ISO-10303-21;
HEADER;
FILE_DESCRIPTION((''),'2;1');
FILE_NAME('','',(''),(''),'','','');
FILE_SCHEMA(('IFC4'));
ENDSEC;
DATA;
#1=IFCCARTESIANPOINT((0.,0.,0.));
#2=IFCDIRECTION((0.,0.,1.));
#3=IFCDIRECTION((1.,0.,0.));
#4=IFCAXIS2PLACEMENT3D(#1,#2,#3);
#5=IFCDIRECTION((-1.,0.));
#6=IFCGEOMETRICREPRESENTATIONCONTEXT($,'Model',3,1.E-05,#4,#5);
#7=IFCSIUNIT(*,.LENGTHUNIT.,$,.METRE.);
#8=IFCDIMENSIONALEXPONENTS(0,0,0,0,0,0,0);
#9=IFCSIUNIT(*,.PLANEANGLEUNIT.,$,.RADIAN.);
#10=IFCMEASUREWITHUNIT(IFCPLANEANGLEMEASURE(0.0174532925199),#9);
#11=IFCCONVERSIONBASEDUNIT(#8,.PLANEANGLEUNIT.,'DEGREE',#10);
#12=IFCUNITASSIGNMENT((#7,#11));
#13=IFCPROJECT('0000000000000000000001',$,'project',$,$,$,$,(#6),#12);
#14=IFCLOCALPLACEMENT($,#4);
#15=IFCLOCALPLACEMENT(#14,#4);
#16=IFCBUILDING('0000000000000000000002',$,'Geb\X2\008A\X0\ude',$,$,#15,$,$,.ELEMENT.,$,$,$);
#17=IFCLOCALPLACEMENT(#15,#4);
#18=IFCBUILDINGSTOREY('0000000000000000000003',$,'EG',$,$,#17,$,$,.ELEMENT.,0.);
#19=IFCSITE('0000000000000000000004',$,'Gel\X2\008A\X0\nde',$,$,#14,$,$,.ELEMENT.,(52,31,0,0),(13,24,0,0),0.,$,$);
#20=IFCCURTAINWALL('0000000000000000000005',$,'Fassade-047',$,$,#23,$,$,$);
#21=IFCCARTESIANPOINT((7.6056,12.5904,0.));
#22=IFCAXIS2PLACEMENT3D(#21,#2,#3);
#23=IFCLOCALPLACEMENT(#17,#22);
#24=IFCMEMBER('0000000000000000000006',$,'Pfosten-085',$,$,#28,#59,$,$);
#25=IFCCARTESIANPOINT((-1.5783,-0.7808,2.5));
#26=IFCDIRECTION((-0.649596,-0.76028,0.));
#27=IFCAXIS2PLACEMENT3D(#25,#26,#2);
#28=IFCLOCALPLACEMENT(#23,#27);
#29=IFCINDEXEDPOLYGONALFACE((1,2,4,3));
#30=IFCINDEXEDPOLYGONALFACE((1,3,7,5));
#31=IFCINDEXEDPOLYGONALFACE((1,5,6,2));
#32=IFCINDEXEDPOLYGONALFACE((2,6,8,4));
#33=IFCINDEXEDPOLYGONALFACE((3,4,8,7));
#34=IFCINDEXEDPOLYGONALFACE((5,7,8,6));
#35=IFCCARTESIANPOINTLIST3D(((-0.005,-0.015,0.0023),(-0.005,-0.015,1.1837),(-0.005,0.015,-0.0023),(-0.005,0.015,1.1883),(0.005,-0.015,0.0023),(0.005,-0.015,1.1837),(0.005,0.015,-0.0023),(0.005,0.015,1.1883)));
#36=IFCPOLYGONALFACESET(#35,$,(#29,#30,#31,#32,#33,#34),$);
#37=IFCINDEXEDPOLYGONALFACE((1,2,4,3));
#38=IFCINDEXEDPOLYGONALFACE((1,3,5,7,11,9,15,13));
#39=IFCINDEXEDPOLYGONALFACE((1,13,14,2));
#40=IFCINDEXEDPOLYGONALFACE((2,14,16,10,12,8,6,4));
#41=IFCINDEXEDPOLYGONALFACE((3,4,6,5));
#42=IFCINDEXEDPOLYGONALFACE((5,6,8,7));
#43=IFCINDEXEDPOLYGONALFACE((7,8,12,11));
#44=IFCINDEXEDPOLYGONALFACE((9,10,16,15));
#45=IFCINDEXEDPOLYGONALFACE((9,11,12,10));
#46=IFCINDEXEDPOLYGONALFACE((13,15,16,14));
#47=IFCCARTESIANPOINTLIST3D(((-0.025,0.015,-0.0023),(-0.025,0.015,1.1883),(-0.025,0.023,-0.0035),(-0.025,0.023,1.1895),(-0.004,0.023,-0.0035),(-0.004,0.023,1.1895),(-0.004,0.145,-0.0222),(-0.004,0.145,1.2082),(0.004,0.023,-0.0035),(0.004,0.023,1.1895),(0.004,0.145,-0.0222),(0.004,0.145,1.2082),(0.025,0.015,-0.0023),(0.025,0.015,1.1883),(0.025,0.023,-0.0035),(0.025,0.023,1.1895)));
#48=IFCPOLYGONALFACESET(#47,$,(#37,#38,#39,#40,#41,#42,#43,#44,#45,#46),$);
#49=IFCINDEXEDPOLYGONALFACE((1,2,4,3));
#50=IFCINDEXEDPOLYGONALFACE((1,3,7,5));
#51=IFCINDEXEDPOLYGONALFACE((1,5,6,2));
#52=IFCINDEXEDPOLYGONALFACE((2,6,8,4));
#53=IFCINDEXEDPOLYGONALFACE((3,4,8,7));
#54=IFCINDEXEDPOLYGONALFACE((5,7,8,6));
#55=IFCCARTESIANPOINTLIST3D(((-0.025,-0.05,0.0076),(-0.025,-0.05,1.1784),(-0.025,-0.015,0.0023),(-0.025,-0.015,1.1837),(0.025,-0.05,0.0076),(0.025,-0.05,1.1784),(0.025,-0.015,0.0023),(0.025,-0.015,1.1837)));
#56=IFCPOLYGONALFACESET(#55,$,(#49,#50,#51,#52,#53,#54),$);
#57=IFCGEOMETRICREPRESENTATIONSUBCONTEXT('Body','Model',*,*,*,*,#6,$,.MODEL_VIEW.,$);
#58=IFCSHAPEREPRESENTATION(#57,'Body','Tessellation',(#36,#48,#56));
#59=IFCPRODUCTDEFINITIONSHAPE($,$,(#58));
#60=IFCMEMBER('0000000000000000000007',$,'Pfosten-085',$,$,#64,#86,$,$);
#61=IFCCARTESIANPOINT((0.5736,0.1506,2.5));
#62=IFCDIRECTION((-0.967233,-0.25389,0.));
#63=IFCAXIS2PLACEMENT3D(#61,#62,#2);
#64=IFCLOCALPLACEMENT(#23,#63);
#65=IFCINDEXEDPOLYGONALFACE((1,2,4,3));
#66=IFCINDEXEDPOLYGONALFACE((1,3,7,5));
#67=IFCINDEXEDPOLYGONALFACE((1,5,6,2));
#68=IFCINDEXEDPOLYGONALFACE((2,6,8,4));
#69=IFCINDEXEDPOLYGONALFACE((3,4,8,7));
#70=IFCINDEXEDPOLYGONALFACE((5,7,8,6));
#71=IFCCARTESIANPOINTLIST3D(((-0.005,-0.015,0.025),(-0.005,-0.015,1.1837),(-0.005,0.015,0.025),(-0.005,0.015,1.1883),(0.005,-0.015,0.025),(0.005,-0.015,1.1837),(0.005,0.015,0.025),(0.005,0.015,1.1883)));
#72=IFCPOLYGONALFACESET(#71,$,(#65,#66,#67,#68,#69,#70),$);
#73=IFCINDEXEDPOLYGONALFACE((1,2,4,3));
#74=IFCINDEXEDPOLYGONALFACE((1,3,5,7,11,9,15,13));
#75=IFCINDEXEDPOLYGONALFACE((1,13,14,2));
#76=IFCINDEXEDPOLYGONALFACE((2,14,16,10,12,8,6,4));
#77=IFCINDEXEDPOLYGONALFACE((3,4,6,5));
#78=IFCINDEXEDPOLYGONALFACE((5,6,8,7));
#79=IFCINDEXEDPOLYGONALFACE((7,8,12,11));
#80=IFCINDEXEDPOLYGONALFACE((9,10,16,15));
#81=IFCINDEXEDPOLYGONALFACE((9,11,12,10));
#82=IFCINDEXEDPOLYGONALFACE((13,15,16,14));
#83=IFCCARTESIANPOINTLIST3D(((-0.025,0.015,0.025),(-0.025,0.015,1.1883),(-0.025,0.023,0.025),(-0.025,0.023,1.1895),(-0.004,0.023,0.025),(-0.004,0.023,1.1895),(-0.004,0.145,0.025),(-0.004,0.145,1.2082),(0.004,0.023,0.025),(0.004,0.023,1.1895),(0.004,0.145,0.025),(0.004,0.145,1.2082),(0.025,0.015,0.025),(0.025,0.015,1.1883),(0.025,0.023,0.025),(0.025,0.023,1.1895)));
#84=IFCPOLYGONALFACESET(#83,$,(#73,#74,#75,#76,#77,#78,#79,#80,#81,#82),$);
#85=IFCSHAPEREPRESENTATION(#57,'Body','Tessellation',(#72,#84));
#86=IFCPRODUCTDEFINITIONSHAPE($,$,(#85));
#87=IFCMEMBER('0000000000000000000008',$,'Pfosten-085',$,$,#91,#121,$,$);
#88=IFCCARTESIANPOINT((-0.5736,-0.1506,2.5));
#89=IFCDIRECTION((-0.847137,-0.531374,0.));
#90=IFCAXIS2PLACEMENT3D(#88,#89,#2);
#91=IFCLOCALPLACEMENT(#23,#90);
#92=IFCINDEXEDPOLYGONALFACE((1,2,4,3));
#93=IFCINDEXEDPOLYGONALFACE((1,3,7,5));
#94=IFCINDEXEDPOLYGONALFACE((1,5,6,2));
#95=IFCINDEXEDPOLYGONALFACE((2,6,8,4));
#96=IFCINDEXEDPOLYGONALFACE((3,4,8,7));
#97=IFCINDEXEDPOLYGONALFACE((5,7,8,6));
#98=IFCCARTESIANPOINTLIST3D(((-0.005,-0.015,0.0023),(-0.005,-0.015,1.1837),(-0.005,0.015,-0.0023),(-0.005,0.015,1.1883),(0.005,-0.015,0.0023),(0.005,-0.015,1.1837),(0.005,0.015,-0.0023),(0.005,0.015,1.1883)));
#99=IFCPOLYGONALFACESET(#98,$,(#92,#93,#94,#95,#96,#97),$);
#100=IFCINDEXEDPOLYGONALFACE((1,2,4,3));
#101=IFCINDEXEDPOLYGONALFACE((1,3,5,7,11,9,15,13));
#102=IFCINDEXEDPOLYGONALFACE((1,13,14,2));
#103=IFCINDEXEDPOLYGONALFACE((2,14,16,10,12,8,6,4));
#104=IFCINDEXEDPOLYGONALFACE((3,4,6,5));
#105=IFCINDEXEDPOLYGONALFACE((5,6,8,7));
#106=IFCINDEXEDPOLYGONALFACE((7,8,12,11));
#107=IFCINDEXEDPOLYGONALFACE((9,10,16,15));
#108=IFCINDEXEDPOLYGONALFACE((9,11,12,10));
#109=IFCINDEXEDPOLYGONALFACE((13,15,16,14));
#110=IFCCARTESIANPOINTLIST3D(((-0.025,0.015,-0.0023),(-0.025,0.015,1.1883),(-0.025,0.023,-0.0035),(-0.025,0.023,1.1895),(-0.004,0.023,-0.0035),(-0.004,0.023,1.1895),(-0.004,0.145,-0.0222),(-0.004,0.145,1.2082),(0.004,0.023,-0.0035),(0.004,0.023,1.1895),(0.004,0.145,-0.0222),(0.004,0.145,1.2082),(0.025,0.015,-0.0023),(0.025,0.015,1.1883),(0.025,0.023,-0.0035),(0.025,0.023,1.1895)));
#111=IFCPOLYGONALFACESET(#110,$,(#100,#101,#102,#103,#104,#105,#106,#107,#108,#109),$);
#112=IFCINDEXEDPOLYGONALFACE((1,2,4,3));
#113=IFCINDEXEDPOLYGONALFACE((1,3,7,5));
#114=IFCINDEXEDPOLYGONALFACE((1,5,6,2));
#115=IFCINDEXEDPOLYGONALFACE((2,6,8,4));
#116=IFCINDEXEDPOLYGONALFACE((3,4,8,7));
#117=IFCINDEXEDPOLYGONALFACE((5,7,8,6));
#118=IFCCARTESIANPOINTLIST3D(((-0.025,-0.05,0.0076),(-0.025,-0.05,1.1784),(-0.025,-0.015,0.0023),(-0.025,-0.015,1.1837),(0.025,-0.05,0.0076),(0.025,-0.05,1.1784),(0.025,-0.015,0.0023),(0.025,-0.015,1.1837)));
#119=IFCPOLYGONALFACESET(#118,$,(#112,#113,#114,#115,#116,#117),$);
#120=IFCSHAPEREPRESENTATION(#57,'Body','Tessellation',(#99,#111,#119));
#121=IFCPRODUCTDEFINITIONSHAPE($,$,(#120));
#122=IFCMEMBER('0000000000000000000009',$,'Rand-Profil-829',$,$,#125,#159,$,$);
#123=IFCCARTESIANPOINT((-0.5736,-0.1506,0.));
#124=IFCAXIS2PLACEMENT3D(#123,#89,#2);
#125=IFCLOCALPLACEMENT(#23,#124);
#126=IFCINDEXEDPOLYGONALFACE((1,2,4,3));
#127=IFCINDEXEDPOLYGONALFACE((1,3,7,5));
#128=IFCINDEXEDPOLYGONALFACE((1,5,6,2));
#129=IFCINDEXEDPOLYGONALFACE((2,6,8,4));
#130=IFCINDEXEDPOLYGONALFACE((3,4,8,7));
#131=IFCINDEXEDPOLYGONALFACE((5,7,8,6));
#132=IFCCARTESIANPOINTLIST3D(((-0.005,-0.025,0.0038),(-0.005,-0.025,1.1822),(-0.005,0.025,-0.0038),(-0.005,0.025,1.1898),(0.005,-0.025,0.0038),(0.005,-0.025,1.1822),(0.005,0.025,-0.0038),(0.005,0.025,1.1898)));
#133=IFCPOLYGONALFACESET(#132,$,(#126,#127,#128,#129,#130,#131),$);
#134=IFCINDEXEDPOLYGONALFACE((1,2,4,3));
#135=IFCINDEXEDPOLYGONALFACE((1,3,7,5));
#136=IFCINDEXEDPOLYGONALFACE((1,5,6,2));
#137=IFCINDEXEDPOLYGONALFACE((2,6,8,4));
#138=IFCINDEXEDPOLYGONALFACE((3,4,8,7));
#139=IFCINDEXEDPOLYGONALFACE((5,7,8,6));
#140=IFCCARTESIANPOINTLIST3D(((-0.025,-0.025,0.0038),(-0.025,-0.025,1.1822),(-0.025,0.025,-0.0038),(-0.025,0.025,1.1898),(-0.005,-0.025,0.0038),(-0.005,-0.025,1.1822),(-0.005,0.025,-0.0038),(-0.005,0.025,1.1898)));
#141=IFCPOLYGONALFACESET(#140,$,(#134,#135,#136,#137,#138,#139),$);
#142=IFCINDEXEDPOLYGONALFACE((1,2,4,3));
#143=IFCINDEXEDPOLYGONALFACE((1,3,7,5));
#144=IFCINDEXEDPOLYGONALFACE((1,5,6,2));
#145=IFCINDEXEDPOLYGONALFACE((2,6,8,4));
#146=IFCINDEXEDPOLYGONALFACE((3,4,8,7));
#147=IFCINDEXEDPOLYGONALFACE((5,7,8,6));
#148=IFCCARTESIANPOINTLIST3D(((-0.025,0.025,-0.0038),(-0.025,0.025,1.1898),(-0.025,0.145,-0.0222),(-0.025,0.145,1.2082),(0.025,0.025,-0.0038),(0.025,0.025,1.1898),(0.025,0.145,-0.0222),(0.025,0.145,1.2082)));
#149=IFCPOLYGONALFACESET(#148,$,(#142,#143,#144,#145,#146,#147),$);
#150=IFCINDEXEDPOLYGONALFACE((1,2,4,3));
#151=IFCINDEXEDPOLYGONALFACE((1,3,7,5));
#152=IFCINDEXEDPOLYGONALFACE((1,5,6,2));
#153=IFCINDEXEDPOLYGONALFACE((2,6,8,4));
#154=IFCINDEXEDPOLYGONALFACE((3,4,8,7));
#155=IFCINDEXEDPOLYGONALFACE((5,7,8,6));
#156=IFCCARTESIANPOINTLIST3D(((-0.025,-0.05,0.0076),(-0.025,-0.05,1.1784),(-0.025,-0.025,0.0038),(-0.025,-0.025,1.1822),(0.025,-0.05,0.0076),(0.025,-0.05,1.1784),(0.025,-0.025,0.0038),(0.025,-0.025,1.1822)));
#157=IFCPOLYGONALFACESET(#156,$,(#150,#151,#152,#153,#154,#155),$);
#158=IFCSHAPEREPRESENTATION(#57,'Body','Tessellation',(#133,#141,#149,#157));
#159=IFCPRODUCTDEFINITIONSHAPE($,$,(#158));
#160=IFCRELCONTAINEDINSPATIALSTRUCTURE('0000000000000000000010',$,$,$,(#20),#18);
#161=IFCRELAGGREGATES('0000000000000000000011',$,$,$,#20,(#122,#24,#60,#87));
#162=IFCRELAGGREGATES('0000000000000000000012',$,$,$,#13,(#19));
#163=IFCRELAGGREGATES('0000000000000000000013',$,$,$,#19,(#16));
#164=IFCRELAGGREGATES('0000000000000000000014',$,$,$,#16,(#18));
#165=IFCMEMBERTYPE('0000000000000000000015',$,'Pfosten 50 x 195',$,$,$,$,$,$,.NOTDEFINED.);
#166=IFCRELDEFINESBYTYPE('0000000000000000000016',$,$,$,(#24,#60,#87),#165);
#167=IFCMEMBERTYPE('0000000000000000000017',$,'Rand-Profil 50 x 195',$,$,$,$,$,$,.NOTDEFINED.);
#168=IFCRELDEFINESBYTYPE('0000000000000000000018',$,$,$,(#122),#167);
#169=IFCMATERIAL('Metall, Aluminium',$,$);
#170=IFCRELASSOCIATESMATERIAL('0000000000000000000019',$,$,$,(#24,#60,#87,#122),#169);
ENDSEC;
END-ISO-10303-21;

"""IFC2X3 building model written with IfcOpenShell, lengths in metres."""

from ifc_helpers import new_model, entity, si_unit, converted_unit, direction, frame, origin_with_axes, place, context, subcontext, project, spatial, polyline, outline, extrude, clip, halfspace, material, type_object, element, aggregate, save


model = new_model("IFC2X3")

# Units and contexts
model_context = context("Model", 3, precision=1e-05, world=origin_with_axes(), true_north=direction((-1.0, 0.0)))
body_context = subcontext(model_context, "Body", "Model", "MODEL_VIEW")
ifc_project = project(units=[si_unit("LENGTHUNIT", "METRE"), converted_unit("PLANEANGLEUNIT", "DEGREE", entity("IfcPlaneAngleMeasure", 0.0174532925199), si_unit("PLANEANGLEUNIT", "RADIAN"), dimensions=[0, 0, 0, 0, 0, 0, 0])], contexts=[model_context])

# Site, building, storey
site_placement = place(None, origin_with_axes())
site = spatial("IfcSite", under=ifc_project, at=site_placement, Name="Gel\u008ande", CompositionType="ELEMENT", RefLatitude=(52, 31, 0, 0), RefLongitude=(13, 24, 0, 0), RefElevation=0.0)
building_placement = place(site_placement, origin_with_axes())
building = spatial("IfcBuilding", under=site, at=building_placement, Name="Geb\u008aude", CompositionType="ELEMENT")
storey_placement = place(building_placement, origin_with_axes())
storey = spatial("IfcBuildingStorey", under=building, at=storey_placement, Name="EG", CompositionType="ELEMENT", Elevation=0.0)

# Curtain wall
curtain_wall_1_placement = place(storey_placement, frame((7.6056, 12.5904, 0.0), z_axis=(0.0, 0.0, 1.0), x_axis=(1.0, 0.0, 0.0)))
curtain_wall_1 = element("IfcCurtainWall", 1, at=curtain_wall_1_placement, inside=storey, Name="Fassade-047")
ifc_material_1 = material(Name="Metall, Aluminium")

# Shared definitions
member_type_1 = type_object("IfcMemberType", Name="Pfosten 50 x 195", PredefinedType="NOTDEFINED")

# Members
member_1_placement = place(curtain_wall_1_placement, frame((-1.5783, -0.7808, 2.5), z_axis=(-0.649596, -0.76028, 0.0), x_axis=(0.0, 0.0, 1.0)))
member_1 = element("IfcMember", 2, at=member_1_placement, type_object=member_type_1, material=ifc_material_1, Name="Pfosten-085", context=body_context, shape_type="Clipping", body=[
    clip(clip(extrude(outline(polyline([(0.015, -0.005), (0.015, 0.005), (-0.015, 0.005), (-0.015, -0.005), (0.015, -0.005)])), frame((0.0, 0.0, -0.0023), z_axis=(0.0, 0.0, 1.0), x_axis=(0.0, 1.0, 0.0)), (0.0, 0.0, 1.0), 1.1906), halfspace(frame((0.0, -0.1772, 1.1589), z_axis=(0.0, 0.151179, -0.988506), x_axis=(0.0, -0.988506, -0.151179)), True)), halfspace(frame((0.0, 0.0, 0.0), z_axis=(0.0, 0.151179, 0.988506), x_axis=(0.0, 0.988506, -0.151179)), True)),
    clip(clip(extrude(outline(polyline([(0.145, -0.004), (0.145, 0.004), (0.023, 0.004), (0.023, 0.025), (0.015, 0.025), (0.015, -0.025), (0.023, -0.025), (0.023, -0.004), (0.145, -0.004)])), frame((0.0, 0.0, -0.0222), z_axis=(0.0, 0.0, 1.0), x_axis=(0.0, 1.0, 0.0)), (0.0, 0.0, 1.0), 1.2304), halfspace(frame((0.0, -0.1772, 1.1589), z_axis=(0.0, 0.151179, -0.988506), x_axis=(0.0, -0.988506, -0.151179)), True)), halfspace(frame((0.0, 0.0, 0.0), z_axis=(0.0, 0.151179, 0.988506), x_axis=(0.0, 0.988506, -0.151179)), True)),
    clip(clip(extrude(outline(polyline([(-0.05, 0.025), (-0.05, -0.025), (-0.015, -0.025), (-0.015, 0.025), (-0.05, 0.025)])), frame((0.0, 0.0, 0.0023), z_axis=(0.0, 0.0, 1.0), x_axis=(0.0, 1.0, 0.0)), (0.0, 0.0, 1.0), 1.1814), halfspace(frame((0.0, -0.1772, 1.1589), z_axis=(0.0, 0.151179, -0.988506), x_axis=(0.0, -0.988506, -0.151179)), True)), halfspace(frame((0.0, 0.0, 0.0), z_axis=(0.0, 0.151179, 0.988506), x_axis=(0.0, 0.988506, -0.151179)), True)),
])
member_2_placement = place(curtain_wall_1_placement, frame((0.5736, 0.1506, 2.5), z_axis=(-0.967233, -0.25389, 0.0), x_axis=(0.0, 0.0, 1.0)))
member_2 = element("IfcMember", 3, at=member_2_placement, type_object=member_type_1, material=ifc_material_1, Name="Pfosten-085", context=body_context, shape_type="Clipping", body=[
    clip(extrude(outline(polyline([(0.015, -0.005), (0.015, 0.005), (-0.015, 0.005), (-0.015, -0.005), (0.015, -0.005)])), frame((0.0, 0.0, 0.025), z_axis=(0.0, 0.0, 1.0), x_axis=(0.0, 1.0, 0.0)), (0.0, 0.0, 1.0), 1.1633), halfspace(frame((0.0, -0.1772, 1.1589), z_axis=(0.0, 0.151179, -0.988506), x_axis=(0.0, -0.988506, -0.151179)), True)),
    clip(extrude(outline(polyline([(0.145, -0.004), (0.145, 0.004), (0.023, 0.004), (0.023, 0.025), (0.015, 0.025), (0.015, -0.025), (0.023, -0.025), (0.023, -0.004), (0.145, -0.004)])), frame((0.0, 0.0, 0.025), z_axis=(0.0, 0.0, 1.0), x_axis=(0.0, 1.0, 0.0)), (0.0, 0.0, 1.0), 1.1832), halfspace(frame((0.0, -0.1772, 1.1589), z_axis=(0.0, 0.151179, -0.988506), x_axis=(0.0, -0.988506, -0.151179)), True)),
])
member_3_placement = place(curtain_wall_1_placement, frame((-0.5736, -0.1506, 2.5), z_axis=(-0.847137, -0.531374, 0.0), x_axis=(0.0, 0.0, 1.0)))
member_3 = element("IfcMember", 4, at=member_3_placement, type_object=member_type_1, material=ifc_material_1, Name="Pfosten-085", context=body_context, shape_type="Clipping", body=[
    clip(clip(extrude(outline(polyline([(0.015, -0.005), (0.015, 0.005), (-0.015, 0.005), (-0.015, -0.005), (0.015, -0.005)])), frame((0.0, 0.0, -0.0023), z_axis=(0.0, 0.0, 1.0), x_axis=(0.0, 1.0, 0.0)), (0.0, 0.0, 1.0), 1.1906), halfspace(frame((0.0, -0.1772, 1.1589), z_axis=(0.0, 0.151179, -0.988506), x_axis=(0.0, -0.988506, -0.151179)), True)), halfspace(frame((0.0, 0.0, 0.0), z_axis=(0.0, 0.151179, 0.988506), x_axis=(0.0, 0.988506, -0.151179)), True)),
    clip(clip(extrude(outline(polyline([(0.145, -0.004), (0.145, 0.004), (0.023, 0.004), (0.023, 0.025), (0.015, 0.025), (0.015, -0.025), (0.023, -0.025), (0.023, -0.004), (0.145, -0.004)])), frame((0.0, 0.0, -0.0222), z_axis=(0.0, 0.0, 1.0), x_axis=(0.0, 1.0, 0.0)), (0.0, 0.0, 1.0), 1.2304), halfspace(frame((0.0, -0.1772, 1.1589), z_axis=(0.0, 0.151179, -0.988506), x_axis=(0.0, -0.988506, -0.151179)), True)), halfspace(frame((0.0, 0.0, 0.0), z_axis=(0.0, 0.151179, 0.988506), x_axis=(0.0, 0.988506, -0.151179)), True)),
    clip(clip(extrude(outline(polyline([(-0.05, 0.025), (-0.05, -0.025), (-0.015, -0.025), (-0.015, 0.025), (-0.05, 0.025)])), frame((0.0, 0.0, 0.0023), z_axis=(0.0, 0.0, 1.0), x_axis=(0.0, 1.0, 0.0)), (0.0, 0.0, 1.0), 1.1814), halfspace(frame((0.0, -0.1772, 1.1589), z_axis=(0.0, 0.151179, -0.988506), x_axis=(0.0, -0.988506, -0.151179)), True)), halfspace(frame((0.0, 0.0, 0.0), z_axis=(0.0, 0.151179, 0.988506), x_axis=(0.0, 0.988506, -0.151179)), True)),
])
member_type_2 = type_object("IfcMemberType", Name="Rand-Profil 50 x 195", PredefinedType="NOTDEFINED")
member_4_placement = place(curtain_wall_1_placement, frame((-0.5736, -0.1506, 0.0), z_axis=(-0.847137, -0.531374, 0.0), x_axis=(0.0, 0.0, 1.0)))
member_4 = element("IfcMember", 5, at=member_4_placement, type_object=member_type_2, material=ifc_material_1, Name="Rand-Profil-829", context=body_context, shape_type="Clipping", body=[
    clip(clip(extrude(outline(polyline([(0.025, -0.005), (0.025, 0.005), (-0.025, 0.005), (-0.025, -0.005), (0.025, -0.005)])), frame((0.0, 0.0, -0.0038), z_axis=(0.0, 0.0, 1.0), x_axis=(0.0, 1.0, 0.0)), (0.0, 0.0, 1.0), 1.1936), halfspace(frame((0.0, -0.1772, 1.1589), z_axis=(0.0, 0.151179, -0.988506), x_axis=(0.0, -0.988506, -0.151179)), True)), halfspace(frame((0.0, 0.0, 0.0), z_axis=(0.0, 0.151179, 0.988506), x_axis=(0.0, 0.988506, -0.151179)), True)),
    clip(clip(extrude(outline(polyline([(0.025, 0.005), (0.025, 0.025), (-0.025, 0.025), (-0.025, 0.005), (0.025, 0.005)])), frame((0.0, 0.0, -0.0038), z_axis=(0.0, 0.0, 1.0), x_axis=(0.0, 1.0, 0.0)), (0.0, 0.0, 1.0), 1.1936), halfspace(frame((0.0, -0.1772, 1.1589), z_axis=(0.0, 0.151179, -0.988506), x_axis=(0.0, -0.988506, -0.151179)), True)), halfspace(frame((0.0, 0.0, 0.0), z_axis=(0.0, 0.151179, 0.988506), x_axis=(0.0, 0.988506, -0.151179)), True)),
    clip(clip(extrude(outline(polyline([(0.145, -0.025), (0.145, 0.025), (0.025, 0.025), (0.025, -0.025), (0.145, -0.025)])), frame((0.0, 0.0, -0.0222), z_axis=(0.0, 0.0, 1.0), x_axis=(0.0, 1.0, 0.0)), (0.0, 0.0, 1.0), 1.2304), halfspace(frame((0.0, -0.1772, 1.1589), z_axis=(0.0, 0.151179, -0.988506), x_axis=(0.0, -0.988506, -0.151179)), True)), halfspace(frame((0.0, 0.0, 0.0), z_axis=(0.0, 0.151179, 0.988506), x_axis=(0.0, 0.988506, -0.151179)), True)),
    clip(clip(extrude(outline(polyline([(-0.05, 0.025), (-0.05, -0.025), (-0.025, -0.025), (-0.025, 0.025), (-0.05, 0.025)])), frame((0.0, 0.0, 0.0038), z_axis=(0.0, 0.0, 1.0), x_axis=(0.0, 1.0, 0.0)), (0.0, 0.0, 1.0), 1.1784), halfspace(frame((0.0, -0.1772, 1.1589), z_axis=(0.0, 0.151179, -0.988506), x_axis=(0.0, -0.988506, -0.151179)), True)), halfspace(frame((0.0, 0.0, 0.0), z_axis=(0.0, 0.151179, 0.988506), x_axis=(0.0, 0.988506, -0.151179)), True)),
])

aggregate(curtain_wall_1, [member_4, member_1, member_2, member_3])

save(model, "model.ifc")
